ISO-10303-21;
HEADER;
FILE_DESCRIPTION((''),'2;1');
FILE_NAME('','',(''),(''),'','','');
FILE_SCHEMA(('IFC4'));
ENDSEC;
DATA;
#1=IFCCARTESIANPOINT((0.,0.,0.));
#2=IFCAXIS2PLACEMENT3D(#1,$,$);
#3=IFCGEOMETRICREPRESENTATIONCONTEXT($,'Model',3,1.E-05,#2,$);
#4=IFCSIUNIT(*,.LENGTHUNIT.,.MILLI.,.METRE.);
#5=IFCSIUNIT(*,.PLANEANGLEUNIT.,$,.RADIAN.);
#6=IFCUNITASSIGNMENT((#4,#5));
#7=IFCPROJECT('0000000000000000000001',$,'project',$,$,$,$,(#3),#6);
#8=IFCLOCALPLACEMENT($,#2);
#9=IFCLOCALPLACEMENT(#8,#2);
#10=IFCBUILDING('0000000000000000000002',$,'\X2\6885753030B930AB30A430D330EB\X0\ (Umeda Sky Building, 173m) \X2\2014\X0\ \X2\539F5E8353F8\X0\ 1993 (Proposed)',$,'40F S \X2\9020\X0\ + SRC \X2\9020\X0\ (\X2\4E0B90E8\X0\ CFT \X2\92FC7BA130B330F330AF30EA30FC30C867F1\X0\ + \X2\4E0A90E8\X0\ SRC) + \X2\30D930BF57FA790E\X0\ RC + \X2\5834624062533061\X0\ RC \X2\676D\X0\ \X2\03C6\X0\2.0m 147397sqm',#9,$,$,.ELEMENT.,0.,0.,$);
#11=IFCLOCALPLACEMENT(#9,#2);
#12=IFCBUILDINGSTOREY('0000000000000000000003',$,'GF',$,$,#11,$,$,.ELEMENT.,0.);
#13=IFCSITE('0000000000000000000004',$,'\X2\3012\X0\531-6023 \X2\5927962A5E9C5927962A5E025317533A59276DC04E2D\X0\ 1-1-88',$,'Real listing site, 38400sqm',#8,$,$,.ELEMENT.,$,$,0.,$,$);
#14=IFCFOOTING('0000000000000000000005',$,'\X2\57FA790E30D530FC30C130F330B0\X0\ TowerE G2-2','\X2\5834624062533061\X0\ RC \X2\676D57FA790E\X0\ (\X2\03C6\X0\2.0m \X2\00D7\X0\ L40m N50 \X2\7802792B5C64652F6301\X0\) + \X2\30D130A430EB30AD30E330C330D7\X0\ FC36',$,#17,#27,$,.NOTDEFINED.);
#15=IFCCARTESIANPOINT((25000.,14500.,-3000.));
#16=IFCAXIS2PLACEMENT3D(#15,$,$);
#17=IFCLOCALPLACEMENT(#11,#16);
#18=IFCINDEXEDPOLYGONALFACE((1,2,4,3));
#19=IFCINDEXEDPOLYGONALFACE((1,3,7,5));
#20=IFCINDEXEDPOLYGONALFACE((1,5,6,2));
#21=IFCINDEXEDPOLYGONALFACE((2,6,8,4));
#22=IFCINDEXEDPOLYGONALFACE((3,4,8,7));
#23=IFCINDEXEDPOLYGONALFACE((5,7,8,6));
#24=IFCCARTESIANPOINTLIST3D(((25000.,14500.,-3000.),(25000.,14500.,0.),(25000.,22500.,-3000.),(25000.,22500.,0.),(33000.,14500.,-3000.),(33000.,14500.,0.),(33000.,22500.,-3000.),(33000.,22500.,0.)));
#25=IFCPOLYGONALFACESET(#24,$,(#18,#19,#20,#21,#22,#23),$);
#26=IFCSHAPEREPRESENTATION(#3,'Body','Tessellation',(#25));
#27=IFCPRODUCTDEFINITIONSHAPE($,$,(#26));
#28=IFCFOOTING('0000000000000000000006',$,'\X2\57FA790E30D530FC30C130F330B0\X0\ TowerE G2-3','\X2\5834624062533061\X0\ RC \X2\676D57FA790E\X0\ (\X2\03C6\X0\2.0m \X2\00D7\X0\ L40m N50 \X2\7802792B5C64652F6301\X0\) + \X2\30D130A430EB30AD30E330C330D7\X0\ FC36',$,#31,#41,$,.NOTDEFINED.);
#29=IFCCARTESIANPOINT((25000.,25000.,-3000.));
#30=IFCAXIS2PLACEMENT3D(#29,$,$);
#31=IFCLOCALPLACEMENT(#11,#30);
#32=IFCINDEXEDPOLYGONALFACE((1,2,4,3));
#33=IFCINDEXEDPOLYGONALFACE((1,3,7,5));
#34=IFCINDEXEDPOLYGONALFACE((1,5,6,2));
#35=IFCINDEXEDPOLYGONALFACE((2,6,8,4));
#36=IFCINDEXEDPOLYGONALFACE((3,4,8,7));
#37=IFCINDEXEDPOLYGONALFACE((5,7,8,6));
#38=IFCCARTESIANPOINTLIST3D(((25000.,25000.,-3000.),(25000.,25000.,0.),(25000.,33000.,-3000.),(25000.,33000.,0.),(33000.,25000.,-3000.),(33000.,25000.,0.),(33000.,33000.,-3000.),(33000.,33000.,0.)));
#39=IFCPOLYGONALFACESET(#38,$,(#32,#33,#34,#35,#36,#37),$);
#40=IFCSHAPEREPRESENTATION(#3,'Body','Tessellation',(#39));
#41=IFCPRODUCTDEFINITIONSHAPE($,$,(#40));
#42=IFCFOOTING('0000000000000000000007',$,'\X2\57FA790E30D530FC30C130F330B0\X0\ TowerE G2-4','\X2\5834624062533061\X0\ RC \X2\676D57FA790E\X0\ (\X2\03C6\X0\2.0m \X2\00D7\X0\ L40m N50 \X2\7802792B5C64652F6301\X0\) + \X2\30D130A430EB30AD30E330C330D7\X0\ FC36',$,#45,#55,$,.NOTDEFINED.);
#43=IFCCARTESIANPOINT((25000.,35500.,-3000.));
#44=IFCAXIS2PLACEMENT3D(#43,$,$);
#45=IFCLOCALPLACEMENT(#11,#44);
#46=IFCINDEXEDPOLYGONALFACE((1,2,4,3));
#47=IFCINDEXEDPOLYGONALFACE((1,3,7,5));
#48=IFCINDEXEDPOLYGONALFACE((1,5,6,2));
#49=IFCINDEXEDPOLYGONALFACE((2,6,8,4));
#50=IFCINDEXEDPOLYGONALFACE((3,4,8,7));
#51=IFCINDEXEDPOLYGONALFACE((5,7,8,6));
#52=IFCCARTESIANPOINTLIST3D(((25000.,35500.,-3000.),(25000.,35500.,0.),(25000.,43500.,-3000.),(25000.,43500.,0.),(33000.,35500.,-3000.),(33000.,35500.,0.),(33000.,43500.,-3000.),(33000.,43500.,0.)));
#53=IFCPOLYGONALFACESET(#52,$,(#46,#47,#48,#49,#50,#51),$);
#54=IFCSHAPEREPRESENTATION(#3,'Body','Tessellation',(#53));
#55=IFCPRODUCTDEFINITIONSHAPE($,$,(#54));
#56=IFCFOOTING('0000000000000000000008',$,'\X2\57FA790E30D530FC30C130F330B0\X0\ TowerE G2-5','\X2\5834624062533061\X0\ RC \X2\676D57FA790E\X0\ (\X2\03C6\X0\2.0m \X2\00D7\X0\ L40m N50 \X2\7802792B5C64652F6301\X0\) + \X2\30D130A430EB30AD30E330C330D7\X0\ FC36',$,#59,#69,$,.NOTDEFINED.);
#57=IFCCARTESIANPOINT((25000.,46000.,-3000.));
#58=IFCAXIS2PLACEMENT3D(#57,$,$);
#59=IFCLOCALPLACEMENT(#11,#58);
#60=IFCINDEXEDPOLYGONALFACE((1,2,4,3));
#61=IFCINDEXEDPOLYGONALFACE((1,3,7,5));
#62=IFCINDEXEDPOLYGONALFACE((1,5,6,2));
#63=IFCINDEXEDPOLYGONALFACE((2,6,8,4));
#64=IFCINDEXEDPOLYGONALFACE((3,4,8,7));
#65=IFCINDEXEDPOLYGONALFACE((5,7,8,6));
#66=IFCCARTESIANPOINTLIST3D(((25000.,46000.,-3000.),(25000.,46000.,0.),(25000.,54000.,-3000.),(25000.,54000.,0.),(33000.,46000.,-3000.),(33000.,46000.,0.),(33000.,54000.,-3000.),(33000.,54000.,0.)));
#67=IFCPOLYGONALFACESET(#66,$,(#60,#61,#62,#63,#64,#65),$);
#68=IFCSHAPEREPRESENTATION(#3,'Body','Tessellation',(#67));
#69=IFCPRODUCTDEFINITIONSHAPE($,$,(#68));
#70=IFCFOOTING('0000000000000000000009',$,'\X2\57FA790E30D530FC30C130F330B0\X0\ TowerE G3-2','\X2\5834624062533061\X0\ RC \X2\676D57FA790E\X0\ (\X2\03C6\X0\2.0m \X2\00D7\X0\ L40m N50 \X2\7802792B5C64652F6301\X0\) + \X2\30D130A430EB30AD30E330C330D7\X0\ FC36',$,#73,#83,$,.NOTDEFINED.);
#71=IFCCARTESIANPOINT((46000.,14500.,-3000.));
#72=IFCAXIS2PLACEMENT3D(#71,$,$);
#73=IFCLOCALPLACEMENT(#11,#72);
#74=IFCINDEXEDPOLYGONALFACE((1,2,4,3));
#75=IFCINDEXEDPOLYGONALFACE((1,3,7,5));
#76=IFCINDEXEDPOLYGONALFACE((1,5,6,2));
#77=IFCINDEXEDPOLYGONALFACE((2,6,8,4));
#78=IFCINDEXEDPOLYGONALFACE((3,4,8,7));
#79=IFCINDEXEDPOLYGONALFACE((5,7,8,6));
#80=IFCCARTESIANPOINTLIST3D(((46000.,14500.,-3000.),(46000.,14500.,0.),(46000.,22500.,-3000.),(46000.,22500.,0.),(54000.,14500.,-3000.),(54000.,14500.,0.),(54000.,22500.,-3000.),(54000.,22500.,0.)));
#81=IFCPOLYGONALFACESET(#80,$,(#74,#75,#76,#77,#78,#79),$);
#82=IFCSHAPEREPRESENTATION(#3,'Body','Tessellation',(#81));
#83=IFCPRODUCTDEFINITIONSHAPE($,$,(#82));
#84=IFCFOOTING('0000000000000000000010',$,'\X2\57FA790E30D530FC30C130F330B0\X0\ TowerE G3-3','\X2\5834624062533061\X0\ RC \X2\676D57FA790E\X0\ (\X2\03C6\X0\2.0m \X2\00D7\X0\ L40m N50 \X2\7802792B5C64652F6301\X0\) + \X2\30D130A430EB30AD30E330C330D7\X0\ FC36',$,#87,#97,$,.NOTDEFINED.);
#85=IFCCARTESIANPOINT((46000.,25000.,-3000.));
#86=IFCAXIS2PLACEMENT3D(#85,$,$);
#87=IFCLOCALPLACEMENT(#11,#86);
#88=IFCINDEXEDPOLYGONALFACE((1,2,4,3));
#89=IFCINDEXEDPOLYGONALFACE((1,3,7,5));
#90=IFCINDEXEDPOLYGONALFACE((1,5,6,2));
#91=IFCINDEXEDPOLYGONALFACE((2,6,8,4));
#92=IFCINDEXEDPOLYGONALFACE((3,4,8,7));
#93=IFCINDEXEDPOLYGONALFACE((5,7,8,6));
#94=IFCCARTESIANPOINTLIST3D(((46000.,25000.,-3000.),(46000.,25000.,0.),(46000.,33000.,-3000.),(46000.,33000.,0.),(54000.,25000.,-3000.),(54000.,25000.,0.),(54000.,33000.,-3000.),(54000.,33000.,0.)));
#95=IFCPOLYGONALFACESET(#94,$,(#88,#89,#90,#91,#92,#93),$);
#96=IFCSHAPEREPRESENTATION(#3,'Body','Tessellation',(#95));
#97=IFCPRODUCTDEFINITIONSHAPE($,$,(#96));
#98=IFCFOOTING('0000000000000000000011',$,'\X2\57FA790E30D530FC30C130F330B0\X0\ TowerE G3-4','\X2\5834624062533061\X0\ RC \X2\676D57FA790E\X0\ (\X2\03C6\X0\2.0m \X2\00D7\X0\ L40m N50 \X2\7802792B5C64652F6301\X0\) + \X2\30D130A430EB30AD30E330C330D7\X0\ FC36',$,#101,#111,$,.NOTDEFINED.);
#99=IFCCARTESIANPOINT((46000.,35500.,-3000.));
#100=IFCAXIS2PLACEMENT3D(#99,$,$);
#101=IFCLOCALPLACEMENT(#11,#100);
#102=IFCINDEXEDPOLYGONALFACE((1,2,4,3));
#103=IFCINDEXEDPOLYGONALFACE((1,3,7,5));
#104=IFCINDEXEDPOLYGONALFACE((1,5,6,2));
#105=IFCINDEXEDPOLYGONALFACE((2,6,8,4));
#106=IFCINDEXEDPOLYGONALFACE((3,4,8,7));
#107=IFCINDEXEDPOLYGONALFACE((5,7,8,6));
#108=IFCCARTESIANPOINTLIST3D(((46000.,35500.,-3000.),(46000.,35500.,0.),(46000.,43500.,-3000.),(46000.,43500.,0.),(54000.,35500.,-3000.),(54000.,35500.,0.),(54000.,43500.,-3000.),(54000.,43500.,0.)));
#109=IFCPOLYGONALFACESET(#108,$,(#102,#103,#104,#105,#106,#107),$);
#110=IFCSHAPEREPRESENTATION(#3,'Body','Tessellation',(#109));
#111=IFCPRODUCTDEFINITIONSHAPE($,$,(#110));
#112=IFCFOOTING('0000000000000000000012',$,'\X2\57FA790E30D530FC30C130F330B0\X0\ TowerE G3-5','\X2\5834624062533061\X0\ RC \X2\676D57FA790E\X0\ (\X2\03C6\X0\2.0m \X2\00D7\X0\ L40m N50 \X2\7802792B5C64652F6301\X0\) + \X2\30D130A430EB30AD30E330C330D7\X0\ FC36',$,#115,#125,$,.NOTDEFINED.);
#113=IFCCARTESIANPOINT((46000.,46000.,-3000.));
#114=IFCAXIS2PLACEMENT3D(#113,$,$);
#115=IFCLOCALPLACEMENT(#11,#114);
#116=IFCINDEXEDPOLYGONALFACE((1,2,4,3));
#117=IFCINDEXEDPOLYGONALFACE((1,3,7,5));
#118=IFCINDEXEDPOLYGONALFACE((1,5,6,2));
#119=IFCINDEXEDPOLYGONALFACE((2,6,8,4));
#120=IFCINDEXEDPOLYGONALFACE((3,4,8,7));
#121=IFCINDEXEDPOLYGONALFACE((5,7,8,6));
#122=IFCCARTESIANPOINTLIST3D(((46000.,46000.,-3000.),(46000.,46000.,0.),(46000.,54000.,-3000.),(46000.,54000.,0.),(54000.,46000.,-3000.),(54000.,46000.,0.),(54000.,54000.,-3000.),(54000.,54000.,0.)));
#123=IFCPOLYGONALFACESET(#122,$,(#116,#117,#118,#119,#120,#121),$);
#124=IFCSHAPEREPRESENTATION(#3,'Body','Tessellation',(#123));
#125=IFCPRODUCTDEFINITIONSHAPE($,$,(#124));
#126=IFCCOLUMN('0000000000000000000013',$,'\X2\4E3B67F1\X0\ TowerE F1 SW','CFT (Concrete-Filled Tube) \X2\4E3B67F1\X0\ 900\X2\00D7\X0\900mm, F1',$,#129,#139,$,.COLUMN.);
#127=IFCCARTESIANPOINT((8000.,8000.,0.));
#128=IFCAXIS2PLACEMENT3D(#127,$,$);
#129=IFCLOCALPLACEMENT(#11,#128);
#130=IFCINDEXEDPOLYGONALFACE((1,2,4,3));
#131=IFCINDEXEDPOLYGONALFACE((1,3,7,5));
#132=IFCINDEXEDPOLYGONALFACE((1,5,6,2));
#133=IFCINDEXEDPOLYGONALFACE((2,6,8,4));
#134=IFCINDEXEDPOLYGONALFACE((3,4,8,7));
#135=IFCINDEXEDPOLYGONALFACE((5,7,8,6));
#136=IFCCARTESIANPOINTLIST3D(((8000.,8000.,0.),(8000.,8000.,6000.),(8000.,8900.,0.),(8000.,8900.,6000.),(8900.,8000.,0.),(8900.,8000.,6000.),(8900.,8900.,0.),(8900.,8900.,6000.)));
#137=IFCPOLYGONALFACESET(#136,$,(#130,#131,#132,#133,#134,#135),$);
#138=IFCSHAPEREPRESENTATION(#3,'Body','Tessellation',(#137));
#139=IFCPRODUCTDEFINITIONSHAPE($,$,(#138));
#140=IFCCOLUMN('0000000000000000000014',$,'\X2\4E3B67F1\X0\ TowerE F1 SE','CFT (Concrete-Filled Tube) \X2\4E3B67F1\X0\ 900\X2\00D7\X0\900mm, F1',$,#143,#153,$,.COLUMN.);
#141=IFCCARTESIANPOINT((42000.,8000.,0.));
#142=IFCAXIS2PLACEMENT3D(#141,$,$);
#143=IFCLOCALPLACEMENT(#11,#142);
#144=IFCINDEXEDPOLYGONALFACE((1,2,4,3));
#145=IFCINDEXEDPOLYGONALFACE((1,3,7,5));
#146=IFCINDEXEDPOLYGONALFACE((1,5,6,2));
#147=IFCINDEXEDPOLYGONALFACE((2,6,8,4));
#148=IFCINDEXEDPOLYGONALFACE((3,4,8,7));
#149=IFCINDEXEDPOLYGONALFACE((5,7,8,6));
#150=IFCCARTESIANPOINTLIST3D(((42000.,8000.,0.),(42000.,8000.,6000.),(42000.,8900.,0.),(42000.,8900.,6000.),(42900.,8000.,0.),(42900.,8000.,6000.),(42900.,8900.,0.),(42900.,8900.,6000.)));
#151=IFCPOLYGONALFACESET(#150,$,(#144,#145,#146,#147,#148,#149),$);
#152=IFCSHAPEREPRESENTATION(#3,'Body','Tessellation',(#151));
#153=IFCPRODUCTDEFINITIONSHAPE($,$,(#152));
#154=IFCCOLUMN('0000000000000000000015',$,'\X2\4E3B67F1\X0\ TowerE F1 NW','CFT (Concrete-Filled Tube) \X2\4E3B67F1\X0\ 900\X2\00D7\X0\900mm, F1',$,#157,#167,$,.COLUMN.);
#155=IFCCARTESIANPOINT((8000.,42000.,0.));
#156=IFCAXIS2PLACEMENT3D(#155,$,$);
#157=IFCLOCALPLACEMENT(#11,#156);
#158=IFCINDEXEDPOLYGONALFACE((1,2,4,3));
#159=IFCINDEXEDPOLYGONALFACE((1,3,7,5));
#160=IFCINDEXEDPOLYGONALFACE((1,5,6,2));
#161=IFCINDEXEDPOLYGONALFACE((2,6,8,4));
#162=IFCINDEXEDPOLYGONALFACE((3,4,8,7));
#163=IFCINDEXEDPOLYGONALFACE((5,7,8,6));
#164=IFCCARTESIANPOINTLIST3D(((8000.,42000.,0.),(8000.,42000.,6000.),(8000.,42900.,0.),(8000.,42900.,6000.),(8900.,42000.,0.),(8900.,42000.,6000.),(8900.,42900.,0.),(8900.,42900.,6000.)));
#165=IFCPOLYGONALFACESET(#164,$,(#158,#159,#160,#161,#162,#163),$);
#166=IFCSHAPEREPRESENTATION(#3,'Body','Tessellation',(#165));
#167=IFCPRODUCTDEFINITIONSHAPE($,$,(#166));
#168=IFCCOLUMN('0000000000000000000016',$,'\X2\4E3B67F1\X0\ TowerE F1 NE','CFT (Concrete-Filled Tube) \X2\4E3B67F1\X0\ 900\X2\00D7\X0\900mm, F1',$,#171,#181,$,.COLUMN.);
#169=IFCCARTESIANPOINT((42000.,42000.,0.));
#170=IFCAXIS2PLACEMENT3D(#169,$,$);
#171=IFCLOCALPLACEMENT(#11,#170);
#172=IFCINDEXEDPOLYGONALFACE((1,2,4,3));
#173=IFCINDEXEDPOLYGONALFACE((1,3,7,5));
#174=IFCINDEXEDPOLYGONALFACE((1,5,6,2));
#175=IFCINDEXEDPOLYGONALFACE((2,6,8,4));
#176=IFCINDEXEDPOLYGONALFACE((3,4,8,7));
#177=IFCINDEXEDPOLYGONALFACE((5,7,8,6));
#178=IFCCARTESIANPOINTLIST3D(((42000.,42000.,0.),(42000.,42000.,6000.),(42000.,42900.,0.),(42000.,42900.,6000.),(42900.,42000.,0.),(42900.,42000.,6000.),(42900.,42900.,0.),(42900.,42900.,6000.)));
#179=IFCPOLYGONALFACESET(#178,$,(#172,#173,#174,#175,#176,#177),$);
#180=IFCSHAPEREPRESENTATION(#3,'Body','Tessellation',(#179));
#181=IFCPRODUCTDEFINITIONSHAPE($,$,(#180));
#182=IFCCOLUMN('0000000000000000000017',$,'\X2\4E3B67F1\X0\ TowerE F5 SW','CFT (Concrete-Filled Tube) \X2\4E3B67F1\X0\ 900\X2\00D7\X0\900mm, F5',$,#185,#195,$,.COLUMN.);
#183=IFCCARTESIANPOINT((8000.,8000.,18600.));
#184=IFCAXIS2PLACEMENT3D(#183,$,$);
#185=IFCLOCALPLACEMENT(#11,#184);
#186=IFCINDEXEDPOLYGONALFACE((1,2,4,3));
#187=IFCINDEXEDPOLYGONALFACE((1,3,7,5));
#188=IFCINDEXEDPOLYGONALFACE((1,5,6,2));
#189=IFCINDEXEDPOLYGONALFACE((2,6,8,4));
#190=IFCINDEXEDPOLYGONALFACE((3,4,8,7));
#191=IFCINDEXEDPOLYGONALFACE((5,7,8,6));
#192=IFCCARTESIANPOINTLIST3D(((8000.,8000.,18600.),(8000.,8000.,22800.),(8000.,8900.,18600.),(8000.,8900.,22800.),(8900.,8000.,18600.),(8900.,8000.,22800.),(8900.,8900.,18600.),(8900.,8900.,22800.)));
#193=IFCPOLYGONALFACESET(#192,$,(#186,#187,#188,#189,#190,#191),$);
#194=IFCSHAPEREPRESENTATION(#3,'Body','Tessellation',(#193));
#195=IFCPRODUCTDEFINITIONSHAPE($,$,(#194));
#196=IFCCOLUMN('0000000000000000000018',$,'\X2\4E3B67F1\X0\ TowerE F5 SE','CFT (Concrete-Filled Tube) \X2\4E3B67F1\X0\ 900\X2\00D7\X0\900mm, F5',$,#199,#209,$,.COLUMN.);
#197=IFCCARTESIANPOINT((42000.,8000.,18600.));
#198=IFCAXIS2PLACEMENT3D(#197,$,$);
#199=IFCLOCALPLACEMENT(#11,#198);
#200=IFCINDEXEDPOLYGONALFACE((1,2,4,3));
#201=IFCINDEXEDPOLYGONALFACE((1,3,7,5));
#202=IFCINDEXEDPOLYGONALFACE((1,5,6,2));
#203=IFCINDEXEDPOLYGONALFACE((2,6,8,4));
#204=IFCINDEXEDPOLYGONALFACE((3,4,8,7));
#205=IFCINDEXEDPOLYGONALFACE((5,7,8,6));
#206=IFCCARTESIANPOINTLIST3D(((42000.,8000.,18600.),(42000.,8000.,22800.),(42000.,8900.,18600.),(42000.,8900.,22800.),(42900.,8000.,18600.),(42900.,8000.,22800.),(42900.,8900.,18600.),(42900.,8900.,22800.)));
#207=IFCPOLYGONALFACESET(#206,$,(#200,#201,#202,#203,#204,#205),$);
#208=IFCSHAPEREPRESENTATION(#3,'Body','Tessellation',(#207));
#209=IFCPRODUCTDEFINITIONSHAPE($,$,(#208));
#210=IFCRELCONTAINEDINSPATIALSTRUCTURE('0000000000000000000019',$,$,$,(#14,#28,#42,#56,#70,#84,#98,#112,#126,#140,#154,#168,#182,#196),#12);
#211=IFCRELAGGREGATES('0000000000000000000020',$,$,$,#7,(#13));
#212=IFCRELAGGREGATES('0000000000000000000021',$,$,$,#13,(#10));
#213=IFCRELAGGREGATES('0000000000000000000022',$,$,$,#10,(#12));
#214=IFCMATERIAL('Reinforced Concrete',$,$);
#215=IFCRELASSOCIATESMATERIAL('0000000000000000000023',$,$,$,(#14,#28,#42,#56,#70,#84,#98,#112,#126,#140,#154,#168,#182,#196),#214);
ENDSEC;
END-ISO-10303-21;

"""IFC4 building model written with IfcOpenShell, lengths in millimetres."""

from ifc_helpers import new_model, si_unit, frame, frame_2d, origin, place, context, project, spatial, rectangle, extrude, material, element, save


model = new_model("IFC4")

# Units and contexts
model_context = context("Model", 3, precision=1e-05, world=origin())
ifc_project = project(units=[si_unit("LENGTHUNIT", "METRE", prefix="MILLI"), si_unit("PLANEANGLEUNIT", "RADIAN")], contexts=[model_context])

# Site, building, storey
site_placement = place(None, origin())
site = spatial("IfcSite", under=ifc_project, at=site_placement, Name="〒531-6023 大阪府大阪市北区大淀中 1-1-88", ObjectType="Real listing site, 38400sqm", CompositionType="ELEMENT", RefElevation=0.0)
building_placement = place(site_placement, origin())
building = spatial("IfcBuilding", under=site, at=building_placement, Name="梅田スカイビル (Umeda Sky Building, 173m) — 原広司 1993 (Proposed)", ObjectType="40F S 造 + SRC 造 (下部 CFT 鋼管コンクリート柱 + 上部 SRC) + ベタ基礎 RC + 場所打ち RC 杭 φ2.0m 147397sqm", CompositionType="ELEMENT", ElevationOfRefHeight=0.0, ElevationOfTerrain=0.0)
storey_placement = place(building_placement, origin())
storey = spatial("IfcBuildingStorey", under=building, at=storey_placement, Name="GF", CompositionType="ELEMENT", Elevation=0.0)

# Footings
ifc_material_1 = material(Name="Reinforced Concrete")
footing_1_placement = place(storey_placement, frame((25000.0, 14500.0, -3000.0)))
element("IfcFooting", 1, at=footing_1_placement, inside=storey, material=ifc_material_1, Name="基礎フーチング TowerE G2-2", Description="場所打ち RC 杭基礎 (φ2.0m × L40m N50 砂礫層支持) + パイルキャップ FC36", PredefinedType="NOTDEFINED", context=model_context, shape_type="SweptSolid", body=[
    extrude(rectangle(XDim=8000.0, YDim=8000.0, at=frame_2d((4000.0, 4000.0))), frame((25000.0, 14500.0, -3000.0)), (0.0, 0.0, 1.0), 3000.0),
])
footing_2_placement = place(storey_placement, frame((25000.0, 25000.0, -3000.0)))
element("IfcFooting", 2, at=footing_2_placement, inside=storey, material=ifc_material_1, Name="基礎フーチング TowerE G2-3", Description="場所打ち RC 杭基礎 (φ2.0m × L40m N50 砂礫層支持) + パイルキャップ FC36", PredefinedType="NOTDEFINED", context=model_context, shape_type="SweptSolid", body=[
    extrude(rectangle(XDim=8000.0, YDim=8000.0, at=frame_2d((4000.0, 4000.0))), frame((25000.0, 25000.0, -3000.0)), (0.0, 0.0, 1.0), 3000.0),
])
footing_3_placement = place(storey_placement, frame((25000.0, 35500.0, -3000.0)))
element("IfcFooting", 3, at=footing_3_placement, inside=storey, material=ifc_material_1, Name="基礎フーチング TowerE G2-4", Description="場所打ち RC 杭基礎 (φ2.0m × L40m N50 砂礫層支持) + パイルキャップ FC36", PredefinedType="NOTDEFINED", context=model_context, shape_type="SweptSolid", body=[
    extrude(rectangle(XDim=8000.0, YDim=8000.0, at=frame_2d((4000.0, 4000.0))), frame((25000.0, 35500.0, -3000.0)), (0.0, 0.0, 1.0), 3000.0),
])
footing_4_placement = place(storey_placement, frame((25000.0, 46000.0, -3000.0)))
element("IfcFooting", 4, at=footing_4_placement, inside=storey, material=ifc_material_1, Name="基礎フーチング TowerE G2-5", Description="場所打ち RC 杭基礎 (φ2.0m × L40m N50 砂礫層支持) + パイルキャップ FC36", PredefinedType="NOTDEFINED", context=model_context, shape_type="SweptSolid", body=[
    extrude(rectangle(XDim=8000.0, YDim=8000.0, at=frame_2d((4000.0, 4000.0))), frame((25000.0, 46000.0, -3000.0)), (0.0, 0.0, 1.0), 3000.0),
])
footing_5_placement = place(storey_placement, frame((46000.0, 14500.0, -3000.0)))
element("IfcFooting", 5, at=footing_5_placement, inside=storey, material=ifc_material_1, Name="基礎フーチング TowerE G3-2", Description="場所打ち RC 杭基礎 (φ2.0m × L40m N50 砂礫層支持) + パイルキャップ FC36", PredefinedType="NOTDEFINED", context=model_context, shape_type="SweptSolid", body=[
    extrude(rectangle(XDim=8000.0, YDim=8000.0, at=frame_2d((4000.0, 4000.0))), frame((46000.0, 14500.0, -3000.0)), (0.0, 0.0, 1.0), 3000.0),
])
footing_6_placement = place(storey_placement, frame((46000.0, 25000.0, -3000.0)))
element("IfcFooting", 6, at=footing_6_placement, inside=storey, material=ifc_material_1, Name="基礎フーチング TowerE G3-3", Description="場所打ち RC 杭基礎 (φ2.0m × L40m N50 砂礫層支持) + パイルキャップ FC36", PredefinedType="NOTDEFINED", context=model_context, shape_type="SweptSolid", body=[
    extrude(rectangle(XDim=8000.0, YDim=8000.0, at=frame_2d((4000.0, 4000.0))), frame((46000.0, 25000.0, -3000.0)), (0.0, 0.0, 1.0), 3000.0),
])
footing_7_placement = place(storey_placement, frame((46000.0, 35500.0, -3000.0)))
element("IfcFooting", 7, at=footing_7_placement, inside=storey, material=ifc_material_1, Name="基礎フーチング TowerE G3-4", Description="場所打ち RC 杭基礎 (φ2.0m × L40m N50 砂礫層支持) + パイルキャップ FC36", PredefinedType="NOTDEFINED", context=model_context, shape_type="SweptSolid", body=[
    extrude(rectangle(XDim=8000.0, YDim=8000.0, at=frame_2d((4000.0, 4000.0))), frame((46000.0, 35500.0, -3000.0)), (0.0, 0.0, 1.0), 3000.0),
])
footing_8_placement = place(storey_placement, frame((46000.0, 46000.0, -3000.0)))
element("IfcFooting", 8, at=footing_8_placement, inside=storey, material=ifc_material_1, Name="基礎フーチング TowerE G3-5", Description="場所打ち RC 杭基礎 (φ2.0m × L40m N50 砂礫層支持) + パイルキャップ FC36", PredefinedType="NOTDEFINED", context=model_context, shape_type="SweptSolid", body=[
    extrude(rectangle(XDim=8000.0, YDim=8000.0, at=frame_2d((4000.0, 4000.0))), frame((46000.0, 46000.0, -3000.0)), (0.0, 0.0, 1.0), 3000.0),
])

# Columns
column_1_placement = place(storey_placement, frame((8000.0, 8000.0, 0.0)))
element("IfcColumn", 9, at=column_1_placement, inside=storey, material=ifc_material_1, Name="主柱 TowerE F1 SW", Description="CFT (Concrete-Filled Tube) 主柱 900×900mm, F1", PredefinedType="COLUMN", context=model_context, shape_type="SweptSolid", body=[
    extrude(rectangle(XDim=900.0, YDim=900.0, at=frame_2d((450.0, 450.0))), frame((8000.0, 8000.0, 0.0)), (0.0, 0.0, 1.0), 6000.0),
])
column_2_placement = place(storey_placement, frame((42000.0, 8000.0, 0.0)))
element("IfcColumn", 10, at=column_2_placement, inside=storey, material=ifc_material_1, Name="主柱 TowerE F1 SE", Description="CFT (Concrete-Filled Tube) 主柱 900×900mm, F1", PredefinedType="COLUMN", context=model_context, shape_type="SweptSolid", body=[
    extrude(rectangle(XDim=900.0, YDim=900.0, at=frame_2d((450.0, 450.0))), frame((42000.0, 8000.0, 0.0)), (0.0, 0.0, 1.0), 6000.0),
])
column_3_placement = place(storey_placement, frame((8000.0, 42000.0, 0.0)))
element("IfcColumn", 11, at=column_3_placement, inside=storey, material=ifc_material_1, Name="主柱 TowerE F1 NW", Description="CFT (Concrete-Filled Tube) 主柱 900×900mm, F1", PredefinedType="COLUMN", context=model_context, shape_type="SweptSolid", body=[
    extrude(rectangle(XDim=900.0, YDim=900.0, at=frame_2d((450.0, 450.0))), frame((8000.0, 42000.0, 0.0)), (0.0, 0.0, 1.0), 6000.0),
])
column_4_placement = place(storey_placement, frame((42000.0, 42000.0, 0.0)))
element("IfcColumn", 12, at=column_4_placement, inside=storey, material=ifc_material_1, Name="主柱 TowerE F1 NE", Description="CFT (Concrete-Filled Tube) 主柱 900×900mm, F1", PredefinedType="COLUMN", context=model_context, shape_type="SweptSolid", body=[
    extrude(rectangle(XDim=900.0, YDim=900.0, at=frame_2d((450.0, 450.0))), frame((42000.0, 42000.0, 0.0)), (0.0, 0.0, 1.0), 6000.0),
])
column_5_placement = place(storey_placement, frame((8000.0, 8000.0, 18600.0)))
element("IfcColumn", 13, at=column_5_placement, inside=storey, material=ifc_material_1, Name="主柱 TowerE F5 SW", Description="CFT (Concrete-Filled Tube) 主柱 900×900mm, F5", PredefinedType="COLUMN", context=model_context, shape_type="SweptSolid", body=[
    extrude(rectangle(XDim=900.0, YDim=900.0, at=frame_2d((450.0, 450.0))), frame((8000.0, 8000.0, 18600.0)), (0.0, 0.0, 1.0), 4200.0),
])
column_6_placement = place(storey_placement, frame((42000.0, 8000.0, 18600.0)))
element("IfcColumn", 14, at=column_6_placement, inside=storey, material=ifc_material_1, Name="主柱 TowerE F5 SE", Description="CFT (Concrete-Filled Tube) 主柱 900×900mm, F5", PredefinedType="COLUMN", context=model_context, shape_type="SweptSolid", body=[
    extrude(rectangle(XDim=900.0, YDim=900.0, at=frame_2d((450.0, 450.0))), frame((42000.0, 8000.0, 18600.0)), (0.0, 0.0, 1.0), 4200.0),
])

save(model, "model.ifc")
